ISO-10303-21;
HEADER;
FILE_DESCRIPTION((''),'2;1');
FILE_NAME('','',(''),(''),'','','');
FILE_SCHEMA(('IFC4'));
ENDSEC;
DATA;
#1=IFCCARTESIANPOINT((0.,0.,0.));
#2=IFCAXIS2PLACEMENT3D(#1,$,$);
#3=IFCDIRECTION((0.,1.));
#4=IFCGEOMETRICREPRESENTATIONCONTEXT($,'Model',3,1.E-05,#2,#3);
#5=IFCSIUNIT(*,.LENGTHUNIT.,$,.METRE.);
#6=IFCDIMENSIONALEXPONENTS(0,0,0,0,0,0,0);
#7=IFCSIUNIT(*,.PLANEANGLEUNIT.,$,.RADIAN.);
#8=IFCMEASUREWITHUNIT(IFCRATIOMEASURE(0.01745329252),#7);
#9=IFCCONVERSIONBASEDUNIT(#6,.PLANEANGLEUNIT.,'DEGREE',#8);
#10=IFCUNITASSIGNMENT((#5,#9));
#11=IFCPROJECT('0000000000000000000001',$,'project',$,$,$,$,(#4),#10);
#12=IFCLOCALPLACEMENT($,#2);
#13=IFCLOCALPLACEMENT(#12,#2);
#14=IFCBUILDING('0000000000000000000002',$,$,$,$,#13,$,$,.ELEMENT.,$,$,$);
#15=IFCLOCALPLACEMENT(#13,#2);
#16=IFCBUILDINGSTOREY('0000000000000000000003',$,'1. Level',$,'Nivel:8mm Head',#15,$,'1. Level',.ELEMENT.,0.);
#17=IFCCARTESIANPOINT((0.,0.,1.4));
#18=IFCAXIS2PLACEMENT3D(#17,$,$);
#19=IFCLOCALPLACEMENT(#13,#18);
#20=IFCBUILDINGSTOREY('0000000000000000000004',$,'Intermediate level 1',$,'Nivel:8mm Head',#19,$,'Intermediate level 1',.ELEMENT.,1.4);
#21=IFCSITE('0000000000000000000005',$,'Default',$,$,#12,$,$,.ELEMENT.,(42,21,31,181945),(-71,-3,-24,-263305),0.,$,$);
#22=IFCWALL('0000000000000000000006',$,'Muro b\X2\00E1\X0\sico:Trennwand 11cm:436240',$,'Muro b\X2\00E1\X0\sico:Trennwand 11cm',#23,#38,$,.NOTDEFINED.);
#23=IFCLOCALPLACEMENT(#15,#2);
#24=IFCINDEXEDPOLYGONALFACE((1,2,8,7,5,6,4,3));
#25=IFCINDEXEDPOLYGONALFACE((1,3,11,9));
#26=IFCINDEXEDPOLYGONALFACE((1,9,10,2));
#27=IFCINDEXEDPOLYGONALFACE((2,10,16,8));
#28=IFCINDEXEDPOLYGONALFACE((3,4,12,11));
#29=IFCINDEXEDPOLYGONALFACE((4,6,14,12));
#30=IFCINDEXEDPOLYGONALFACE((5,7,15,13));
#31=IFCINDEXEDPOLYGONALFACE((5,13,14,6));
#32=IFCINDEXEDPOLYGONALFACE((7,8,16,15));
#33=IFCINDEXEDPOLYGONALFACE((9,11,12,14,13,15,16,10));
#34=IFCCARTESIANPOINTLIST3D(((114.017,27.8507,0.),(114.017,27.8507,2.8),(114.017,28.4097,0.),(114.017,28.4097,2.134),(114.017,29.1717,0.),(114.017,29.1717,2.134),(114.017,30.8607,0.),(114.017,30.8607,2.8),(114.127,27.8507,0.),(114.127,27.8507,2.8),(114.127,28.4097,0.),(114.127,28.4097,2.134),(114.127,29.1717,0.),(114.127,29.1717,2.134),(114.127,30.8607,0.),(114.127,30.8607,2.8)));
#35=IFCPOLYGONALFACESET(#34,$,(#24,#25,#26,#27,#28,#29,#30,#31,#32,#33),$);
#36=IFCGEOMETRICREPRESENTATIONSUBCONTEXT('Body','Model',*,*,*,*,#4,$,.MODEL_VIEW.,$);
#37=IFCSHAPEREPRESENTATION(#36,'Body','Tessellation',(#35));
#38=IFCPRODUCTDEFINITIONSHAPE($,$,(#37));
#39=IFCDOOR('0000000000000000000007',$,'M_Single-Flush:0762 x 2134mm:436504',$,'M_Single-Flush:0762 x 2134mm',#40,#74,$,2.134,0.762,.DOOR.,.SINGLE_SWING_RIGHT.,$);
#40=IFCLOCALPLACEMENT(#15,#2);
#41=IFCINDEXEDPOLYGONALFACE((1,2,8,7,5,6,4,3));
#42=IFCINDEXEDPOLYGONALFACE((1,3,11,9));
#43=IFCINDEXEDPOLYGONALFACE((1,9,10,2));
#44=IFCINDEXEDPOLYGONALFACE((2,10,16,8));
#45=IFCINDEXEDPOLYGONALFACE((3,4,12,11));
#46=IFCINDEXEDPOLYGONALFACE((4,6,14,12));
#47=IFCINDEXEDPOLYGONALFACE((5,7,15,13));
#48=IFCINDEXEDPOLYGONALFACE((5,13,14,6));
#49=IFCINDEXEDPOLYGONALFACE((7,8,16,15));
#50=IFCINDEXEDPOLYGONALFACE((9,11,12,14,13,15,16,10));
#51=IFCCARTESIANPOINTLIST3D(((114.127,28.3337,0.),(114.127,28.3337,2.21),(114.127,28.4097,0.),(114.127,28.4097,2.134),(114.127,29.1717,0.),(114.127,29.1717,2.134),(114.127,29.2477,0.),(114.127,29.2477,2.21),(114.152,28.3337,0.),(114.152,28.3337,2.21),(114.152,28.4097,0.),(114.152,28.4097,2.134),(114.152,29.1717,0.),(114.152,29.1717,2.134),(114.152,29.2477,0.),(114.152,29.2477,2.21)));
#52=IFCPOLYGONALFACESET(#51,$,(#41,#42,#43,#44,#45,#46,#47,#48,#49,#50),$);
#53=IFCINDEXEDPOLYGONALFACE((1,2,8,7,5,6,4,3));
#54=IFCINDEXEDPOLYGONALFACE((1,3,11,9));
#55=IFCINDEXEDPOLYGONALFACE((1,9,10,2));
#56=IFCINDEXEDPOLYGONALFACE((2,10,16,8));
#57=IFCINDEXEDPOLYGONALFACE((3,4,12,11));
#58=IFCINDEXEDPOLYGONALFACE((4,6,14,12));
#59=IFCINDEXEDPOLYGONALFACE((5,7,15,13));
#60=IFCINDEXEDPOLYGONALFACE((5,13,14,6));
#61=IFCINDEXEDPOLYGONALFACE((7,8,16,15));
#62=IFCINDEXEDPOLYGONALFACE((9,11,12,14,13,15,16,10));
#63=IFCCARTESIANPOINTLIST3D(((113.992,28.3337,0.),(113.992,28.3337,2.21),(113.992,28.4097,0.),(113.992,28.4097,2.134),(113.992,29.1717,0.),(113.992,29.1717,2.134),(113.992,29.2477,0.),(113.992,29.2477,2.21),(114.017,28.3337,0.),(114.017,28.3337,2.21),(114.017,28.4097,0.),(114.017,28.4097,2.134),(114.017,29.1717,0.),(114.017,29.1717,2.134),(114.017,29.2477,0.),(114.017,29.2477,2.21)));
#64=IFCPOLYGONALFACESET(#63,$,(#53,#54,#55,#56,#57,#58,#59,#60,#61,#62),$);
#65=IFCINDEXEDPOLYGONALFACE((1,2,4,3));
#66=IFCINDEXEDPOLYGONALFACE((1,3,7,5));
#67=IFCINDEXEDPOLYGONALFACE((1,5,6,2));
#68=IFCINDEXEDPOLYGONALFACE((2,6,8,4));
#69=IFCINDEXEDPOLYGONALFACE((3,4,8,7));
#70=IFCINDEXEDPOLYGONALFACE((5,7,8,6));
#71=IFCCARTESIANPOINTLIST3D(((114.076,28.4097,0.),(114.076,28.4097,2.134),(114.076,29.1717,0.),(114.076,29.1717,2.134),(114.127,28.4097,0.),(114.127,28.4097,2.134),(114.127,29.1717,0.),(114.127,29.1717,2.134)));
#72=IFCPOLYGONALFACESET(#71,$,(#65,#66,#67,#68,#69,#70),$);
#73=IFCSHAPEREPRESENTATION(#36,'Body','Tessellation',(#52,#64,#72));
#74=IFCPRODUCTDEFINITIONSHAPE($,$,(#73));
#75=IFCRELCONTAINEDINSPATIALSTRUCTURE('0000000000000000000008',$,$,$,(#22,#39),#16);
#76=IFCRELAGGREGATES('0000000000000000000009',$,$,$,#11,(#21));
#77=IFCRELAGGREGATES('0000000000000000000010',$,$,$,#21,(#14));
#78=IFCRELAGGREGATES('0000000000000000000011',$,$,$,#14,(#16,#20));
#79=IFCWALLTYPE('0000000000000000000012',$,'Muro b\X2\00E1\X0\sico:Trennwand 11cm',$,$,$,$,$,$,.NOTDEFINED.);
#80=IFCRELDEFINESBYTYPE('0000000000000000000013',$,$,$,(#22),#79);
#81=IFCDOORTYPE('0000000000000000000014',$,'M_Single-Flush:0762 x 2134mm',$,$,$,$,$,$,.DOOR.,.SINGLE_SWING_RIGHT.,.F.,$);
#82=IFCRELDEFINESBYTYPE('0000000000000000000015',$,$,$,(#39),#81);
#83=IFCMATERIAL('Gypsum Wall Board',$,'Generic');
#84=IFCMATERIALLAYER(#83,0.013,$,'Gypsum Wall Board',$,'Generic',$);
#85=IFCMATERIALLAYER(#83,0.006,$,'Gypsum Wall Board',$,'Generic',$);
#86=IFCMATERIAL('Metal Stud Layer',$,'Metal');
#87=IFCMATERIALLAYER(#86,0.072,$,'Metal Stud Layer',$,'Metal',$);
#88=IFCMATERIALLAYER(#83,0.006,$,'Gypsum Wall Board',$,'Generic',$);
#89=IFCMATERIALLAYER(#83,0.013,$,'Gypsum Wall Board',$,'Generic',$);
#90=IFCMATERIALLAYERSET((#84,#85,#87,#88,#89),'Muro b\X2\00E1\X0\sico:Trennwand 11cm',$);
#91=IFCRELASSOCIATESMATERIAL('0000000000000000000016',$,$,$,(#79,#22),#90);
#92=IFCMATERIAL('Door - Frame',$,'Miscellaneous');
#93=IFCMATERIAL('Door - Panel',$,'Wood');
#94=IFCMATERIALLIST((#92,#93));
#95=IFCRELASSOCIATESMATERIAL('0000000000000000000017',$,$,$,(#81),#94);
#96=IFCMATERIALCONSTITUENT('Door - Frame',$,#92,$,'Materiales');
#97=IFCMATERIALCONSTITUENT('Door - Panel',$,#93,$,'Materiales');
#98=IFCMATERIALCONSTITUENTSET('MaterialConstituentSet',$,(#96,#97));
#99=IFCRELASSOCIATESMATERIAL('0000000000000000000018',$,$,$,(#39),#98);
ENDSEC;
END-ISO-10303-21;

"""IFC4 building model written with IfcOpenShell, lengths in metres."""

from ifc_helpers import new_model, entity, si_unit, converted_unit, direction, frame, frame_2d, origin, origin_2d_with_axis, place, context, subcontext, project, spatial, polyline, rectangle, outline, extrude, source, transform, mapped, material, material_list, layer, layer_set, layer_usage, constituent, constituent_set, type_object, type_shapes, element, fill, save


model = new_model("IFC4")

# Units and contexts
model_context = context("Model", 3, precision=1e-05, world=origin(), true_north=direction((0.0, 1.0)))
body_context = subcontext(model_context, "Body", "Model", "MODEL_VIEW")
ifc_project = project(units=[si_unit("LENGTHUNIT", "METRE"), converted_unit("PLANEANGLEUNIT", "DEGREE", entity("IfcRatioMeasure", 0.01745329252), si_unit("PLANEANGLEUNIT", "RADIAN"), dimensions=[0, 0, 0, 0, 0, 0, 0])], contexts=[model_context])

# Site, building, storey
site_placement = place(None, origin())
site = spatial("IfcSite", under=ifc_project, at=site_placement, Name="Default", CompositionType="ELEMENT", RefLatitude=(42, 21, 31, 181945), RefLongitude=(-71, -3, -24, -263305), RefElevation=0.0)
building_placement = place(site_placement, origin())
building = spatial("IfcBuilding", under=site, at=building_placement, CompositionType="ELEMENT")
storey_1_placement = place(building_placement, origin())
storey_1 = spatial("IfcBuildingStorey", under=building, at=storey_1_placement, Name="1. Level", ObjectType="Nivel:8mm Head", LongName="1. Level", CompositionType="ELEMENT", Elevation=0.0)

# Shared definitions
storey_2_placement = place(building_placement, frame((0.0, 0.0, 1.4)))
storey_2 = spatial("IfcBuildingStorey", under=building, at=storey_2_placement, Name="Intermediate level 1", ObjectType="Nivel:8mm Head", LongName="Intermediate level 1", CompositionType="ELEMENT", Elevation=1.4)

# Shared definitions
ifc_material_1 = material(Name="Gypsum Wall Board", Category="Generic")
ifc_layer_1 = layer(ifc_material_1, 0.013, Name="Gypsum Wall Board", Category="Generic")
ifc_layer_2 = layer(ifc_material_1, 0.006, Name="Gypsum Wall Board", Category="Generic")
ifc_material_2 = material(Name="Metal Stud Layer", Category="Metal")
ifc_layer_3 = layer(ifc_material_2, 0.072, Name="Metal Stud Layer", Category="Metal")
ifc_layer_4 = layer(ifc_material_1, 0.006, Name="Gypsum Wall Board", Category="Generic")
ifc_layer_5 = layer(ifc_material_1, 0.013, Name="Gypsum Wall Board", Category="Generic")
ifc_layer_set_1 = layer_set([ifc_layer_1, ifc_layer_2, ifc_layer_3, ifc_layer_4, ifc_layer_5], Name="Muro básico:Trennwand 11cm")
wall_type_1 = type_object("IfcWallType", Name="Muro básico:Trennwand 11cm", PredefinedType="NOTDEFINED", material=ifc_layer_set_1)
ifc_material_3 = material(Name="Door - Frame", Category="Miscellaneous")
ifc_material_4 = material(Name="Door - Panel", Category="Wood")
ifc_material_list_1 = material_list([ifc_material_3, ifc_material_4])
door_type_1 = type_object("IfcDoorType", Name="M_Single-Flush:0762 x 2134mm", OperationType="SINGLE_SWING_RIGHT", ParameterTakesPrecedence=False, PredefinedType="DOOR", material=ifc_material_list_1)
shared_shape_1 = source(origin(), body_context, "Body", "SweptSolid", [
    extrude(outline(polyline([(-0.457, -1.124), (0.457, -1.124), (0.457, 1.086), (0.381, 1.086), (0.381, -1.048), (-0.381, -1.048), (-0.381, 1.086), (-0.457, 1.086), (-0.457, -1.124)])), frame((0.381, 0.11, 1.086), z_axis=(0.0, 1.0, 0.0), x_axis=(1.0, 0.0, 0.0)), (0.0, 0.0, 1.0), 0.025),
    extrude(outline(polyline([(-1.124, -0.457), (1.086, -0.457), (1.086, -0.381), (-1.048, -0.381), (-1.048, 0.381), (1.086, 0.381), (1.086, 0.457), (-1.124, 0.457), (-1.124, -0.457)])), frame((0.381, -0.025, 1.086), z_axis=(0.0, 1.0, 0.0), x_axis=(0.0, 0.0, -1.0)), (0.0, 0.0, 1.0), 0.025),
    extrude(rectangle(XDim=0.051, YDim=0.762, at=origin_2d_with_axis()), frame((0.381, 0.0845, 0.0), z_axis=(0.0, 0.0, 1.0), x_axis=(0.0, 1.0, 0.0)), (0.0, 0.0, 1.0), 2.134),
])
type_shapes(door_type_1, [shared_shape_1])

# Wall, opening, door
ifc_layer_usage_1 = layer_usage(ifc_layer_set_1, "AXIS2", "NEGATIVE", 0.055)
wall_1_placement = place(storey_1_placement, frame((114.072, 30.8607, 0.0), z_axis=(0.0, 0.0, 1.0), x_axis=(0.0, -1.0, 0.0)))
wall_1 = element("IfcWall", 1, at=wall_1_placement, inside=storey_1, type_object=wall_type_1, material=ifc_layer_usage_1, Name="Muro básico:Trennwand 11cm:436240", ObjectType="Muro básico:Trennwand 11cm", PredefinedType="NOTDEFINED", context=body_context, shape_type="SweptSolid", body=[
    extrude(rectangle(XDim=3.01, YDim=0.11, at=frame_2d((1.505, 0.0), x_axis=(-1.0, 0.0))), origin(), (0.0, 0.0, 1.0), 2.8),
])
opening_1_placement = place(wall_1_placement, frame((1.689, -0.055, 0.0)))
opening_1 = element("IfcOpeningElement", 2, at=opening_1_placement, cuts=wall_1, ObjectType="Opening", PredefinedType="OPENING", context=body_context, shape_type="SweptSolid", body=[
    extrude(rectangle(XDim=0.762, YDim=2.134, at=frame_2d((1.067, 0.381), x_axis=(0.0, 1.0))), frame((0.0, 0.0, 0.0), z_axis=(0.0, 1.0, 0.0), x_axis=(0.0, 0.0, 1.0)), (0.0, 0.0, 1.0), 0.11),
])
ifc_constituent_1 = constituent(ifc_material_3, Name="Door - Frame", Category="Materiales")
ifc_constituent_2 = constituent(ifc_material_4, Name="Door - Panel", Category="Materiales")
ifc_constituent_set_1 = constituent_set(constituents=[ifc_constituent_1, ifc_constituent_2], Name="MaterialConstituentSet")
door_1_placement = place(opening_1_placement, origin())
door_1 = element("IfcDoor", 3, at=door_1_placement, inside=storey_1, type_object=door_type_1, material=ifc_constituent_set_1, Name="M_Single-Flush:0762 x 2134mm:436504", ObjectType="M_Single-Flush:0762 x 2134mm", OperationType="SINGLE_SWING_RIGHT", OverallHeight=2.134, OverallWidth=0.762, PredefinedType="DOOR", context=body_context, shape_type="MappedRepresentation", body=[
    mapped(shared_shape_1, transform((0.0, 0.0, 0.0), scale=1.0)),
])
fill(opening_1, door_1)

save(model, "model.ifc")
